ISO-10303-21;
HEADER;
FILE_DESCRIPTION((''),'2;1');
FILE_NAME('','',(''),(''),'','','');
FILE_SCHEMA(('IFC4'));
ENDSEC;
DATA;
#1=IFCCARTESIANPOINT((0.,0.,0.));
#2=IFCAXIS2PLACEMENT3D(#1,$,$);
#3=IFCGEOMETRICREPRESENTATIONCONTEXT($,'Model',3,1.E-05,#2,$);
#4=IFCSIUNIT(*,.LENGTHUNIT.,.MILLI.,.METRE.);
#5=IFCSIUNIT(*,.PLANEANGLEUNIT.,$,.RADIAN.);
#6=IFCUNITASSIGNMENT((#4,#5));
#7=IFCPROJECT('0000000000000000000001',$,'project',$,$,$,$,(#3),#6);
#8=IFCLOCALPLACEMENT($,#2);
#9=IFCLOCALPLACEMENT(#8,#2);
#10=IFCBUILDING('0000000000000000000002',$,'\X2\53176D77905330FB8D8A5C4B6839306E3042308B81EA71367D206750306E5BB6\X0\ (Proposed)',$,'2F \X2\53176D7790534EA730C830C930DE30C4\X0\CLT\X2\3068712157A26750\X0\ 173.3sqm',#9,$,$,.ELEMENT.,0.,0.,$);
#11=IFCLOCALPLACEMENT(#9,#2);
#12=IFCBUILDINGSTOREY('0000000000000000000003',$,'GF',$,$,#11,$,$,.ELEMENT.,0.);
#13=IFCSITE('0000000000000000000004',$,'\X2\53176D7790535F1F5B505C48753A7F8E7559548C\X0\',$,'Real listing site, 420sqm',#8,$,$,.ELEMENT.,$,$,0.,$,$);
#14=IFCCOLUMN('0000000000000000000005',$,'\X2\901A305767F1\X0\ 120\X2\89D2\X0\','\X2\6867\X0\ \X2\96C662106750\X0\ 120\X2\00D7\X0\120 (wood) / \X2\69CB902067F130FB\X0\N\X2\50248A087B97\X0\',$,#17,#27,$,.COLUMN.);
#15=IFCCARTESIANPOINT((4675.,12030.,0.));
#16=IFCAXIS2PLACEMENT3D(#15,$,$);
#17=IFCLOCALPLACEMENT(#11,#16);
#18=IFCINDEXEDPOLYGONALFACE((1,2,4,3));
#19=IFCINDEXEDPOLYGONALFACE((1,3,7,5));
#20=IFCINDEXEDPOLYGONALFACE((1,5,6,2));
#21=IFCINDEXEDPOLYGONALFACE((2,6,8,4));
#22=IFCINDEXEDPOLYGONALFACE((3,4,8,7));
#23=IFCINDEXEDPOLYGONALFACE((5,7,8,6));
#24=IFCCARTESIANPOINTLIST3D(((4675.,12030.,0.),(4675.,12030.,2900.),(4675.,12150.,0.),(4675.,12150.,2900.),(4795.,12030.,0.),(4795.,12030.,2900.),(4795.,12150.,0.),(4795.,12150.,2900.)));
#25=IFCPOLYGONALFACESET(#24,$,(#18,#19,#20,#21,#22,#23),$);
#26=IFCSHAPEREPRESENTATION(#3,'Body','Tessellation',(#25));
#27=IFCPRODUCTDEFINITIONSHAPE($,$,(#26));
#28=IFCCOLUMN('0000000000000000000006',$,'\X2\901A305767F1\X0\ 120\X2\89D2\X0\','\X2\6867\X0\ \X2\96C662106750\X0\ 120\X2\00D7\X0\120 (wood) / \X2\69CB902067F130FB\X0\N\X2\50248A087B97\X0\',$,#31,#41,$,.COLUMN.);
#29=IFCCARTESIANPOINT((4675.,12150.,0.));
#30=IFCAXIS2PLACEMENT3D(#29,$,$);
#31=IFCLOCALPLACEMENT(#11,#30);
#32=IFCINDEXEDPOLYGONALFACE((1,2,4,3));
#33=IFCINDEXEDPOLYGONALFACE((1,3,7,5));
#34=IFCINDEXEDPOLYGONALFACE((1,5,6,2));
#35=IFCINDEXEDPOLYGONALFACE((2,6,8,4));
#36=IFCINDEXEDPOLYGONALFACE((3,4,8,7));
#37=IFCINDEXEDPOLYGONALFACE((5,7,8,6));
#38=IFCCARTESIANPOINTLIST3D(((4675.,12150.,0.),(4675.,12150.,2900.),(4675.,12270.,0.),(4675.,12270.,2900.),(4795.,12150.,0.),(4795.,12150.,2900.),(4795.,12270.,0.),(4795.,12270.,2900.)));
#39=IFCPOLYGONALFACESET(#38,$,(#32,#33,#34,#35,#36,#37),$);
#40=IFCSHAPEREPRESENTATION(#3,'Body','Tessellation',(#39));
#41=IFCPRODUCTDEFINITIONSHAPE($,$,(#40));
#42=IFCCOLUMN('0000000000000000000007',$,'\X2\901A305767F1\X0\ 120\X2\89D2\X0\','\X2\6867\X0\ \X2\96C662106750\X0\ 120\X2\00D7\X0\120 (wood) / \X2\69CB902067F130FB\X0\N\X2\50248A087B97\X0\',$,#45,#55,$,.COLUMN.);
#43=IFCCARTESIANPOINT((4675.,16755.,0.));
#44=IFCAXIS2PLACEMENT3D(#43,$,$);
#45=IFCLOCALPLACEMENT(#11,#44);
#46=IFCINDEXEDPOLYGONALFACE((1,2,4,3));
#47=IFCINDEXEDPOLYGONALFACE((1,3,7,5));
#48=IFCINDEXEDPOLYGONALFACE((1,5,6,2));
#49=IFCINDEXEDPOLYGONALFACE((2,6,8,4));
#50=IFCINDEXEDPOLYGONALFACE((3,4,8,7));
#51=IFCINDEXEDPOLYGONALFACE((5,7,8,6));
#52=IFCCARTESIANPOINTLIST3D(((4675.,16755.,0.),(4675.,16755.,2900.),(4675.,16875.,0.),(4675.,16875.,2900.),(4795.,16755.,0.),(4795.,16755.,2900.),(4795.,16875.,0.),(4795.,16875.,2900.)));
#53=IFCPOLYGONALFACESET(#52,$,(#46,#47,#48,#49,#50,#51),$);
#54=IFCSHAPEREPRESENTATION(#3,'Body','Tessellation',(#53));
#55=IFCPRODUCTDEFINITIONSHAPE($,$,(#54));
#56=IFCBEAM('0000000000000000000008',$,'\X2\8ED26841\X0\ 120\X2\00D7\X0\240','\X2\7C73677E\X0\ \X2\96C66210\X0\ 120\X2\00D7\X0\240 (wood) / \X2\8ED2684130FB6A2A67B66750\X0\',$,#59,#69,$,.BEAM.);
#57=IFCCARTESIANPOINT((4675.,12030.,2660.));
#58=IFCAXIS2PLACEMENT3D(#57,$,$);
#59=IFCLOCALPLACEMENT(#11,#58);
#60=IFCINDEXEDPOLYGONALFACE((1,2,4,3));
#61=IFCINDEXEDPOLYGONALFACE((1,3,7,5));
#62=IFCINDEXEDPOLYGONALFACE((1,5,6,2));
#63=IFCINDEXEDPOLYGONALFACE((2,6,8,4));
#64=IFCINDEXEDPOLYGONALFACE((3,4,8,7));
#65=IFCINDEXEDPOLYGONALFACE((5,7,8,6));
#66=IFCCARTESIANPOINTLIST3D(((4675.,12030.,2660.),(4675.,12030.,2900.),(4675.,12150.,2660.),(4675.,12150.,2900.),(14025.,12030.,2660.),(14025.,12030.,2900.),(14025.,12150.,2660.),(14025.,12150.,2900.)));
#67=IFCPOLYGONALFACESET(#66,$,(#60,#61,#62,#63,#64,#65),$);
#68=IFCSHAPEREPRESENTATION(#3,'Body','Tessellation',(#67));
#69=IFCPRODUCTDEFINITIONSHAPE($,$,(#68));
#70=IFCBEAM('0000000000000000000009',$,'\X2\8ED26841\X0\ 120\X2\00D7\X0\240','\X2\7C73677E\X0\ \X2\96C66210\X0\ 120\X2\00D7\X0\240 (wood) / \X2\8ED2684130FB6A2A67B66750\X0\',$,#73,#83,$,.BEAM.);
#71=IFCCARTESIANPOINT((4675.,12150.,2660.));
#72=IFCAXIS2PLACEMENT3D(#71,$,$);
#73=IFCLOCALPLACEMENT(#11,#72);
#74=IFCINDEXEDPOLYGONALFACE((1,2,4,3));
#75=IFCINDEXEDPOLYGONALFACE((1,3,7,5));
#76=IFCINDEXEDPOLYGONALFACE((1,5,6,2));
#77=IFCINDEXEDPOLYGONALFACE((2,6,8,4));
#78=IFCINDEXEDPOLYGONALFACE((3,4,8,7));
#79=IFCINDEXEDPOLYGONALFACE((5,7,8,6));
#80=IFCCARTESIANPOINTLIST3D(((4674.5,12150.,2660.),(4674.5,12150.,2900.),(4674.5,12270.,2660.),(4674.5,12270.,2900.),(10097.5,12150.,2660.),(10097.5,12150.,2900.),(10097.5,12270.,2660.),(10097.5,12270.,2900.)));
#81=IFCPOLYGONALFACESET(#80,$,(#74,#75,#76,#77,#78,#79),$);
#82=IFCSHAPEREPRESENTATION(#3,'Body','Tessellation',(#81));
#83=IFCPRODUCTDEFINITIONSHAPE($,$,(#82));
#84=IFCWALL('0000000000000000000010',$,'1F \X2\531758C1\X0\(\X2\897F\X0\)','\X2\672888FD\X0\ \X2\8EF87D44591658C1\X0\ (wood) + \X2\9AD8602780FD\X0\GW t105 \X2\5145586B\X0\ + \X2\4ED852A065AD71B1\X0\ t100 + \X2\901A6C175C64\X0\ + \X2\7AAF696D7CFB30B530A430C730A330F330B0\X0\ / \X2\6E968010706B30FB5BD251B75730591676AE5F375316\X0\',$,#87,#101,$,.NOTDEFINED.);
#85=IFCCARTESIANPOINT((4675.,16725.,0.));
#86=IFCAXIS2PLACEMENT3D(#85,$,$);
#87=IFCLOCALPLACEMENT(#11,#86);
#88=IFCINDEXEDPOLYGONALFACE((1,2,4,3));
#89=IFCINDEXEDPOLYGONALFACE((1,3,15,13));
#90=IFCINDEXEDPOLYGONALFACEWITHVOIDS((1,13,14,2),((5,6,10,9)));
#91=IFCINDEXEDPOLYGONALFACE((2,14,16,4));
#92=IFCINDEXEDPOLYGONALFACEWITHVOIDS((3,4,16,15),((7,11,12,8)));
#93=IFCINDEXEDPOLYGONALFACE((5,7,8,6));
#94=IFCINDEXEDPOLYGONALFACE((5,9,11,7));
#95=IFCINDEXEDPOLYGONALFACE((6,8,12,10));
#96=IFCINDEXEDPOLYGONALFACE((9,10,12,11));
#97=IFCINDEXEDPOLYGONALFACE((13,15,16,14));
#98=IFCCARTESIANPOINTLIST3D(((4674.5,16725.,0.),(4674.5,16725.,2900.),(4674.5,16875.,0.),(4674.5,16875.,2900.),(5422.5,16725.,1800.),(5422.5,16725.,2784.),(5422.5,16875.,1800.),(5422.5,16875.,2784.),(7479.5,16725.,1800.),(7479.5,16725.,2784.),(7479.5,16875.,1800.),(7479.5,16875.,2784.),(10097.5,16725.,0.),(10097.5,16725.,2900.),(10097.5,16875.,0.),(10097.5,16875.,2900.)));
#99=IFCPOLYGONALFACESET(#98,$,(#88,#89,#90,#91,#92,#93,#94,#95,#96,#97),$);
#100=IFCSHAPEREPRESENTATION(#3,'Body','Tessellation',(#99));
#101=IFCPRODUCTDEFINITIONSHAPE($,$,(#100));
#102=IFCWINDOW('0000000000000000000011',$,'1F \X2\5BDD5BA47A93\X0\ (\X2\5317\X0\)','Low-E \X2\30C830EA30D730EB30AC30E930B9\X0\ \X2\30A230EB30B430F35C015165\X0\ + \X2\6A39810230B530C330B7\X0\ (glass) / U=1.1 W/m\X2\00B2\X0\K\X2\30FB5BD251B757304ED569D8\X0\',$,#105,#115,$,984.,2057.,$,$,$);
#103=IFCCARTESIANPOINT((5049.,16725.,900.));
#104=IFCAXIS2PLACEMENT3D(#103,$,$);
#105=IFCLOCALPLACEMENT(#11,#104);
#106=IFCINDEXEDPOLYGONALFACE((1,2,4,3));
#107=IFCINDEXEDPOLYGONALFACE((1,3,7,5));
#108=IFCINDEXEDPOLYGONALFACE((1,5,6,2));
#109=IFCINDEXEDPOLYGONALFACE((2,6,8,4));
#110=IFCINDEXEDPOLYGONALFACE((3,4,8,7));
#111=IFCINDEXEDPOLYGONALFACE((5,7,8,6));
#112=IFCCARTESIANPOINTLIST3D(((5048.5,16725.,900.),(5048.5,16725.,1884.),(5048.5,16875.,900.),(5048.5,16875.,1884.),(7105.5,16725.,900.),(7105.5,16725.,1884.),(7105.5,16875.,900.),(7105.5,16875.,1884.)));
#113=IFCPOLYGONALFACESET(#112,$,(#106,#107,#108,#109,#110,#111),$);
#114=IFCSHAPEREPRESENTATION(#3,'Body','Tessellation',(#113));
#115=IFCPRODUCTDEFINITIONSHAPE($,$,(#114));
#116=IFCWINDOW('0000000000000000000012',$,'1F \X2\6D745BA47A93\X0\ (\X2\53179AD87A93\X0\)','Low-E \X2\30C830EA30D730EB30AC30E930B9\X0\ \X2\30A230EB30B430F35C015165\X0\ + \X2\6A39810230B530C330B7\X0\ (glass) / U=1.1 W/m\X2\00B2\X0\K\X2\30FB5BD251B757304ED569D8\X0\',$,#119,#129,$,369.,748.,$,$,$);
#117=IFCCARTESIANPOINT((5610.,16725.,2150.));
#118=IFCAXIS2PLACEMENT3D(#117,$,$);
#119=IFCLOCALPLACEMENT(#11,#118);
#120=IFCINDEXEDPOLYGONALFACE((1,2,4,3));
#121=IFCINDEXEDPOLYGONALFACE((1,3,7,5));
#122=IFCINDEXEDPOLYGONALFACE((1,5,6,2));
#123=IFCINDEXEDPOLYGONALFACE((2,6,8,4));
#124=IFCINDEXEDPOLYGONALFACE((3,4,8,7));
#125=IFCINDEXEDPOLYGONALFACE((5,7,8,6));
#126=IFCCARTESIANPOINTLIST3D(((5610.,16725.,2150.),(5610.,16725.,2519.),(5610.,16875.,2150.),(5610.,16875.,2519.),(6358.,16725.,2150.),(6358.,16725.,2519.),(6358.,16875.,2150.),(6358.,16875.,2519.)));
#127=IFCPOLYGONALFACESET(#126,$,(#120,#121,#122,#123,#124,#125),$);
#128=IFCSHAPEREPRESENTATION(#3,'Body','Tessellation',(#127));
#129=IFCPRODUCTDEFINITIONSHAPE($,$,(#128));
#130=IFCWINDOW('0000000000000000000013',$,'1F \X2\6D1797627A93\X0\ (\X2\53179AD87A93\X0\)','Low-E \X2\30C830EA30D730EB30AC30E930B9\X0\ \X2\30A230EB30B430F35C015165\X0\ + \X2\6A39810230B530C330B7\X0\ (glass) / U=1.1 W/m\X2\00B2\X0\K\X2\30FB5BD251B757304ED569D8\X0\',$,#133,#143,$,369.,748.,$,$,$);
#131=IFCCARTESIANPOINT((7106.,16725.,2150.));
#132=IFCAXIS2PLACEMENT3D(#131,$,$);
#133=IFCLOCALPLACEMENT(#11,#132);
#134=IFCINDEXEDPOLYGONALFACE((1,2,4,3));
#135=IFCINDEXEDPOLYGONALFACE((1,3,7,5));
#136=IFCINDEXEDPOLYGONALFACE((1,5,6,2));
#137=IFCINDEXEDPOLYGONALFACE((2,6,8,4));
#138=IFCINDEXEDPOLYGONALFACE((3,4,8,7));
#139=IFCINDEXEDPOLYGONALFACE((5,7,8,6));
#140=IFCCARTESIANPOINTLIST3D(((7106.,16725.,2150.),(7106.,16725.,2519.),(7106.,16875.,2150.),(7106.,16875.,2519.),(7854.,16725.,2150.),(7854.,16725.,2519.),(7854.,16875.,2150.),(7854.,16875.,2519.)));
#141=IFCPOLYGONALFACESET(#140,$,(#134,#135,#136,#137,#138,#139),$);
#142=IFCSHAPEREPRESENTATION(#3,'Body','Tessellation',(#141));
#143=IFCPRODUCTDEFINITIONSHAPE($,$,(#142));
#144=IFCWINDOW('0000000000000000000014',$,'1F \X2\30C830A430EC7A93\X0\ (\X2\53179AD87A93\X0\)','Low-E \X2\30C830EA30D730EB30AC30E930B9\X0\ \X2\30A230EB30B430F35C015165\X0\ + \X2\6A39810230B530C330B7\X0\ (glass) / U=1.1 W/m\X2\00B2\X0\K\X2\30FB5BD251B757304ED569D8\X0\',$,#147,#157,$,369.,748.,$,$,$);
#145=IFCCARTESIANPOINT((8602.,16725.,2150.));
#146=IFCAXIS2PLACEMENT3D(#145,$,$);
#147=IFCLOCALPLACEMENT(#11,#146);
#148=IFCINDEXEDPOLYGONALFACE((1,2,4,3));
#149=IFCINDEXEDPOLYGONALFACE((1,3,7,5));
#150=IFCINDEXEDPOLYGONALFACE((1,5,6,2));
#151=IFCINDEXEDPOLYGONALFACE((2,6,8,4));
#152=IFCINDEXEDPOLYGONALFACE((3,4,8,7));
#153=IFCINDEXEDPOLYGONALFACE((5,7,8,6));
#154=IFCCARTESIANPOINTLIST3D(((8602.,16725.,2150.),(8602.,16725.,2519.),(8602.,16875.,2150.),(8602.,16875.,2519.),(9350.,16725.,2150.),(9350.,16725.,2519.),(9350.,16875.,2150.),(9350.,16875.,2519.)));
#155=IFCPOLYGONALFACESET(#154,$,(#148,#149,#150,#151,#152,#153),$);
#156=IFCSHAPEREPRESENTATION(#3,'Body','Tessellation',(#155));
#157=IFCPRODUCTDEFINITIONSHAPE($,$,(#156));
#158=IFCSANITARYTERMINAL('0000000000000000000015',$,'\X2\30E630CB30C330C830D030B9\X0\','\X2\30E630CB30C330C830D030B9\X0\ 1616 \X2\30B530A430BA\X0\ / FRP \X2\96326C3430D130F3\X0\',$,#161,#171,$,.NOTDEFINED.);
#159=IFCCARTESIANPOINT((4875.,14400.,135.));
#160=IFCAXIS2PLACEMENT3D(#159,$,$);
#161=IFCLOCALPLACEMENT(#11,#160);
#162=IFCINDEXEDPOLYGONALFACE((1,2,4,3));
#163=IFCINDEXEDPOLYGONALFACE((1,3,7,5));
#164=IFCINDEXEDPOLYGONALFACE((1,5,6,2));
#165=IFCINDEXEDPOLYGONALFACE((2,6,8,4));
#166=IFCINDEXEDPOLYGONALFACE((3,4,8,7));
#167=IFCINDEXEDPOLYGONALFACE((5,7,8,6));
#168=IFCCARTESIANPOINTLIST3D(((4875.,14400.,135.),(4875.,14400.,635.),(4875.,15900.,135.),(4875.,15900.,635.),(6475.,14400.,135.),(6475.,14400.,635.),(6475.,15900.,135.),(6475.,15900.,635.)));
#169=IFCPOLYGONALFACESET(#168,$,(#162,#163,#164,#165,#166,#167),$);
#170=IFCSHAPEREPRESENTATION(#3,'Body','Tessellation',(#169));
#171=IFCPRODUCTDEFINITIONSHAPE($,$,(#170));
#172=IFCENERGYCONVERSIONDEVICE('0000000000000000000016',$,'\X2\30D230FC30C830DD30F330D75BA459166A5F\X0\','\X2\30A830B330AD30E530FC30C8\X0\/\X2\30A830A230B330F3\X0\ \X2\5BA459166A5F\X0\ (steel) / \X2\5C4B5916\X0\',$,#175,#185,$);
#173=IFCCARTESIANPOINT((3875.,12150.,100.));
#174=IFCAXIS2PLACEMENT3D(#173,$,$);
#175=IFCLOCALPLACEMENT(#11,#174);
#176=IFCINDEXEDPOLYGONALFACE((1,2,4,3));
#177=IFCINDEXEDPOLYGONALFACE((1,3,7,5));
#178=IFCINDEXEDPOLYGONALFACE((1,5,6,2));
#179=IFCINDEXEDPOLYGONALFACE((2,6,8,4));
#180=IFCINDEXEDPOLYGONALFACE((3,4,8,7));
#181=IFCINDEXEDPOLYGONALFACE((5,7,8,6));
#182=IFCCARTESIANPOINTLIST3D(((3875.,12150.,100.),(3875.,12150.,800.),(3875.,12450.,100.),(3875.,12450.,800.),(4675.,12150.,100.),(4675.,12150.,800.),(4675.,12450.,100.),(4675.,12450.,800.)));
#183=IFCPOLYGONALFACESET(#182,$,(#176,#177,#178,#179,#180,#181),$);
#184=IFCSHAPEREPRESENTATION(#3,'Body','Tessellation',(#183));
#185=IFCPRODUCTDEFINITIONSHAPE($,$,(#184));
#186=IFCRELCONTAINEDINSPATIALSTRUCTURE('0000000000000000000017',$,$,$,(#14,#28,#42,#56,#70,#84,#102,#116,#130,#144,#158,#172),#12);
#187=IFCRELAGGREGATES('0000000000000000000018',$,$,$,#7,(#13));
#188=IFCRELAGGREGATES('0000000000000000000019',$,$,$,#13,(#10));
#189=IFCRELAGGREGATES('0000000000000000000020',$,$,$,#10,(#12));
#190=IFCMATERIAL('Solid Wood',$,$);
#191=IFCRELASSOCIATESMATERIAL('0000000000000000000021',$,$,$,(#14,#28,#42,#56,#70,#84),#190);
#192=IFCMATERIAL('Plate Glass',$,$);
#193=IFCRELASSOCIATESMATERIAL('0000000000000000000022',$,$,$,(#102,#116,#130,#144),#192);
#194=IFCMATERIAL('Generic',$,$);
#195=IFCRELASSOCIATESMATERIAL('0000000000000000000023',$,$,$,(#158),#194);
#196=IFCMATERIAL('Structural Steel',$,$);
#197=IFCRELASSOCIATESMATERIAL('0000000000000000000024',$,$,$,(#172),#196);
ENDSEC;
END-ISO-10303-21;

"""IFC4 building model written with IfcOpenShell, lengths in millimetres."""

from ifc_helpers import new_model, si_unit, frame, frame_2d, origin, place, context, project, spatial, rectangle, extrude, material, element, fill, save


model = new_model("IFC4")

# Units and contexts
model_context = context("Model", 3, precision=1e-05, world=origin())
ifc_project = project(units=[si_unit("LENGTHUNIT", "METRE", prefix="MILLI"), si_unit("PLANEANGLEUNIT", "RADIAN")], contexts=[model_context])

# Site, building, storey
site_placement = place(None, origin())
site = spatial("IfcSite", under=ifc_project, at=site_placement, Name="北海道弟子屈町美留和", ObjectType="Real listing site, 420sqm", CompositionType="ELEMENT", RefElevation=0.0)
building_placement = place(site_placement, origin())
building = spatial("IfcBuilding", under=site, at=building_placement, Name="北海道・越屋根のある自然素材の家 (Proposed)", ObjectType="2F 北海道产トドマツCLTと無垢材 173.3sqm", CompositionType="ELEMENT", ElevationOfRefHeight=0.0, ElevationOfTerrain=0.0)
storey_placement = place(building_placement, origin())
storey = spatial("IfcBuildingStorey", under=building, at=storey_placement, Name="GF", CompositionType="ELEMENT", Elevation=0.0)

# Columns
ifc_material_1 = material(Name="Solid Wood")
column_1_placement = place(storey_placement, frame((4675.0, 12030.0, 0.0)))
element("IfcColumn", 1, at=column_1_placement, inside=storey, material=ifc_material_1, Name="通し柱 120角", Description="桧 集成材 120×120 (wood) / 構造柱・N値計算", PredefinedType="COLUMN", context=model_context, shape_type="SweptSolid", body=[
    extrude(rectangle(XDim=120.0, YDim=120.0, at=frame_2d((60.0, 60.0))), frame((4675.0, 12030.0, 0.0)), (0.0, 0.0, 1.0), 2900.0),
])
column_2_placement = place(storey_placement, frame((4675.0, 12150.0, 0.0)))
element("IfcColumn", 2, at=column_2_placement, inside=storey, material=ifc_material_1, Name="通し柱 120角", Description="桧 集成材 120×120 (wood) / 構造柱・N値計算", PredefinedType="COLUMN", context=model_context, shape_type="SweptSolid", body=[
    extrude(rectangle(XDim=120.0, YDim=120.0, at=frame_2d((60.0, 60.0))), frame((4675.0, 12150.0, 0.0)), (0.0, 0.0, 1.0), 2900.0),
])
column_3_placement = place(storey_placement, frame((4675.0, 16755.0, 0.0)))
element("IfcColumn", 3, at=column_3_placement, inside=storey, material=ifc_material_1, Name="通し柱 120角", Description="桧 集成材 120×120 (wood) / 構造柱・N値計算", PredefinedType="COLUMN", context=model_context, shape_type="SweptSolid", body=[
    extrude(rectangle(XDim=120.0, YDim=120.0, at=frame_2d((60.0, 60.0))), frame((4675.0, 16755.0, 0.0)), (0.0, 0.0, 1.0), 2900.0),
])

# Beams
beam_1_placement = place(storey_placement, frame((4675.0, 12030.0, 2660.0)))
element("IfcBeam", 4, at=beam_1_placement, inside=storey, material=ifc_material_1, Name="軒桁 120×240", Description="米松 集成 120×240 (wood) / 軒桁・横架材", PredefinedType="BEAM", context=model_context, shape_type="SweptSolid", body=[
    extrude(rectangle(XDim=9350.0, YDim=120.0, at=frame_2d((4675.0, 60.0))), frame((4675.0, 12030.0, 2660.0)), (0.0, 0.0, 1.0), 240.0),
])
beam_2_placement = place(storey_placement, frame((4675.0, 12150.0, 2660.0)))
element("IfcBeam", 5, at=beam_2_placement, inside=storey, material=ifc_material_1, Name="軒桁 120×240", Description="米松 集成 120×240 (wood) / 軒桁・横架材", PredefinedType="BEAM", context=model_context, shape_type="SweptSolid", body=[
    extrude(rectangle(XDim=5423.0, YDim=120.0, at=frame_2d((2711.0, 60.0))), frame((4675.0, 12150.0, 2660.0)), (0.0, 0.0, 1.0), 240.0),
])

# Wall, openings, windows
wall_1_placement = place(storey_placement, frame((4675.0, 16725.0, 0.0)))
wall_1 = element("IfcWall", 6, at=wall_1_placement, inside=storey, material=ifc_material_1, Name="1F 北壁(西)", Description="木製 軸組外壁 (wood) + 高性能GW t105 充填 + 付加断熱 t100 + 通気層 + 窯業系サイディング / 準耐火・寒冷地外皮強化", PredefinedType="NOTDEFINED", context=model_context, shape_type="SweptSolid", body=[
    extrude(rectangle(XDim=5423.0, YDim=150.0, at=frame_2d((2711.0, 75.0))), frame((4675.0, 16725.0, 0.0)), (0.0, 0.0, 1.0), 2900.0),
])
opening_1_placement = place(storey_placement, frame((5049.0, 16725.0, 900.0)))
opening_1 = element("IfcOpeningElement", 7, at=opening_1_placement, cuts=wall_1, PredefinedType="NOTDEFINED", context=model_context, shape_type="SweptSolid", body=[
    extrude(rectangle(XDim=2057.0, YDim=150.0, at=frame_2d((1028.0, 75.0))), frame((5049.0, 16725.0, 900.0)), (0.0, 0.0, 1.0), 984.0),
])
opening_2_placement = place(storey_placement, frame((5610.0, 16725.0, 2150.0)))
opening_2 = element("IfcOpeningElement", 8, at=opening_2_placement, cuts=wall_1, PredefinedType="NOTDEFINED", context=model_context, shape_type="SweptSolid", body=[
    extrude(rectangle(XDim=748.0, YDim=150.0, at=frame_2d((374.0, 75.0))), frame((5610.0, 16725.0, 2150.0)), (0.0, 0.0, 1.0), 369.0),
])
opening_3_placement = place(storey_placement, frame((7106.0, 16725.0, 2150.0)))
opening_3 = element("IfcOpeningElement", 9, at=opening_3_placement, cuts=wall_1, PredefinedType="NOTDEFINED", context=model_context, shape_type="SweptSolid", body=[
    extrude(rectangle(XDim=748.0, YDim=150.0, at=frame_2d((374.0, 75.0))), frame((7106.0, 16725.0, 2150.0)), (0.0, 0.0, 1.0), 369.0),
])
opening_4_placement = place(storey_placement, frame((8602.0, 16725.0, 2150.0)))
opening_4 = element("IfcOpeningElement", 10, at=opening_4_placement, cuts=wall_1, PredefinedType="NOTDEFINED", context=model_context, shape_type="SweptSolid", body=[
    extrude(rectangle(XDim=748.0, YDim=150.0, at=frame_2d((374.0, 75.0))), frame((8602.0, 16725.0, 2150.0)), (0.0, 0.0, 1.0), 369.0),
])
ifc_material_2 = material(Name="Plate Glass")
window_1_placement = place(storey_placement, frame((5049.0, 16725.0, 900.0)))
window_1 = element("IfcWindow", 11, at=window_1_placement, inside=storey, material=ifc_material_2, Name="1F 寝室窓 (北)", Description="Low-E トリプルガラス アルゴン封入 + 樹脂サッシ (glass) / U=1.1 W/m²K・寒冷地仕様", OverallHeight=984.0, OverallWidth=2057.0, context=model_context, shape_type="SweptSolid", body=[
    extrude(rectangle(XDim=2057.0, YDim=150.0, at=frame_2d((1028.0, 75.0))), frame((5049.0, 16725.0, 900.0)), (0.0, 0.0, 1.0), 984.0),
])
fill(opening_1, window_1)
window_2_placement = place(storey_placement, frame((5610.0, 16725.0, 2150.0)))
window_2 = element("IfcWindow", 12, at=window_2_placement, inside=storey, material=ifc_material_2, Name="1F 浴室窓 (北高窓)", Description="Low-E トリプルガラス アルゴン封入 + 樹脂サッシ (glass) / U=1.1 W/m²K・寒冷地仕様", OverallHeight=369.0, OverallWidth=748.0, context=model_context, shape_type="SweptSolid", body=[
    extrude(rectangle(XDim=748.0, YDim=150.0, at=frame_2d((374.0, 75.0))), frame((5610.0, 16725.0, 2150.0)), (0.0, 0.0, 1.0), 369.0),
])
fill(opening_2, window_2)
window_3_placement = place(storey_placement, frame((7106.0, 16725.0, 2150.0)))
window_3 = element("IfcWindow", 13, at=window_3_placement, inside=storey, material=ifc_material_2, Name="1F 洗面窓 (北高窓)", Description="Low-E トリプルガラス アルゴン封入 + 樹脂サッシ (glass) / U=1.1 W/m²K・寒冷地仕様", OverallHeight=369.0, OverallWidth=748.0, context=model_context, shape_type="SweptSolid", body=[
    extrude(rectangle(XDim=748.0, YDim=150.0, at=frame_2d((374.0, 75.0))), frame((7106.0, 16725.0, 2150.0)), (0.0, 0.0, 1.0), 369.0),
])
fill(opening_3, window_3)
window_4_placement = place(storey_placement, frame((8602.0, 16725.0, 2150.0)))
window_4 = element("IfcWindow", 14, at=window_4_placement, inside=storey, material=ifc_material_2, Name="1F トイレ窓 (北高窓)", Description="Low-E トリプルガラス アルゴン封入 + 樹脂サッシ (glass) / U=1.1 W/m²K・寒冷地仕様", OverallHeight=369.0, OverallWidth=748.0, context=model_context, shape_type="SweptSolid", body=[
    extrude(rectangle(XDim=748.0, YDim=150.0, at=frame_2d((374.0, 75.0))), frame((8602.0, 16725.0, 2150.0)), (0.0, 0.0, 1.0), 369.0),
])
fill(opening_4, window_4)

# Shared definitions
ifc_material_3 = material(Name="Generic")

# Sanitary terminal
sanitary_terminal_placement = place(storey_placement, frame((4875.0, 14400.0, 135.0)))
element("IfcSanitaryTerminal", 15, at=sanitary_terminal_placement, inside=storey, material=ifc_material_3, Name="ユニットバス", Description="ユニットバス 1616 サイズ / FRP 防水パン", PredefinedType="NOTDEFINED", context=model_context, shape_type="SweptSolid", body=[
    extrude(rectangle(XDim=1600.0, YDim=1500.0, at=frame_2d((800.0, 750.0))), frame((4875.0, 14400.0, 135.0)), (0.0, 0.0, 1.0), 500.0),
])

# Energy conversion device
ifc_material_4 = material(Name="Structural Steel")
energy_conversion_device_placement = place(storey_placement, frame((3875.0, 12150.0, 100.0)))
element("IfcEnergyConversionDevice", 16, at=energy_conversion_device_placement, inside=storey, material=ifc_material_4, Name="ヒートポンプ室外機", Description="エコキュート/エアコン 室外機 (steel) / 屋外", context=model_context, shape_type="SweptSolid", body=[
    extrude(rectangle(XDim=800.0, YDim=300.0, at=frame_2d((400.0, 150.0))), frame((3875.0, 12150.0, 100.0)), (0.0, 0.0, 1.0), 700.0),
])

save(model, "model.ifc")
